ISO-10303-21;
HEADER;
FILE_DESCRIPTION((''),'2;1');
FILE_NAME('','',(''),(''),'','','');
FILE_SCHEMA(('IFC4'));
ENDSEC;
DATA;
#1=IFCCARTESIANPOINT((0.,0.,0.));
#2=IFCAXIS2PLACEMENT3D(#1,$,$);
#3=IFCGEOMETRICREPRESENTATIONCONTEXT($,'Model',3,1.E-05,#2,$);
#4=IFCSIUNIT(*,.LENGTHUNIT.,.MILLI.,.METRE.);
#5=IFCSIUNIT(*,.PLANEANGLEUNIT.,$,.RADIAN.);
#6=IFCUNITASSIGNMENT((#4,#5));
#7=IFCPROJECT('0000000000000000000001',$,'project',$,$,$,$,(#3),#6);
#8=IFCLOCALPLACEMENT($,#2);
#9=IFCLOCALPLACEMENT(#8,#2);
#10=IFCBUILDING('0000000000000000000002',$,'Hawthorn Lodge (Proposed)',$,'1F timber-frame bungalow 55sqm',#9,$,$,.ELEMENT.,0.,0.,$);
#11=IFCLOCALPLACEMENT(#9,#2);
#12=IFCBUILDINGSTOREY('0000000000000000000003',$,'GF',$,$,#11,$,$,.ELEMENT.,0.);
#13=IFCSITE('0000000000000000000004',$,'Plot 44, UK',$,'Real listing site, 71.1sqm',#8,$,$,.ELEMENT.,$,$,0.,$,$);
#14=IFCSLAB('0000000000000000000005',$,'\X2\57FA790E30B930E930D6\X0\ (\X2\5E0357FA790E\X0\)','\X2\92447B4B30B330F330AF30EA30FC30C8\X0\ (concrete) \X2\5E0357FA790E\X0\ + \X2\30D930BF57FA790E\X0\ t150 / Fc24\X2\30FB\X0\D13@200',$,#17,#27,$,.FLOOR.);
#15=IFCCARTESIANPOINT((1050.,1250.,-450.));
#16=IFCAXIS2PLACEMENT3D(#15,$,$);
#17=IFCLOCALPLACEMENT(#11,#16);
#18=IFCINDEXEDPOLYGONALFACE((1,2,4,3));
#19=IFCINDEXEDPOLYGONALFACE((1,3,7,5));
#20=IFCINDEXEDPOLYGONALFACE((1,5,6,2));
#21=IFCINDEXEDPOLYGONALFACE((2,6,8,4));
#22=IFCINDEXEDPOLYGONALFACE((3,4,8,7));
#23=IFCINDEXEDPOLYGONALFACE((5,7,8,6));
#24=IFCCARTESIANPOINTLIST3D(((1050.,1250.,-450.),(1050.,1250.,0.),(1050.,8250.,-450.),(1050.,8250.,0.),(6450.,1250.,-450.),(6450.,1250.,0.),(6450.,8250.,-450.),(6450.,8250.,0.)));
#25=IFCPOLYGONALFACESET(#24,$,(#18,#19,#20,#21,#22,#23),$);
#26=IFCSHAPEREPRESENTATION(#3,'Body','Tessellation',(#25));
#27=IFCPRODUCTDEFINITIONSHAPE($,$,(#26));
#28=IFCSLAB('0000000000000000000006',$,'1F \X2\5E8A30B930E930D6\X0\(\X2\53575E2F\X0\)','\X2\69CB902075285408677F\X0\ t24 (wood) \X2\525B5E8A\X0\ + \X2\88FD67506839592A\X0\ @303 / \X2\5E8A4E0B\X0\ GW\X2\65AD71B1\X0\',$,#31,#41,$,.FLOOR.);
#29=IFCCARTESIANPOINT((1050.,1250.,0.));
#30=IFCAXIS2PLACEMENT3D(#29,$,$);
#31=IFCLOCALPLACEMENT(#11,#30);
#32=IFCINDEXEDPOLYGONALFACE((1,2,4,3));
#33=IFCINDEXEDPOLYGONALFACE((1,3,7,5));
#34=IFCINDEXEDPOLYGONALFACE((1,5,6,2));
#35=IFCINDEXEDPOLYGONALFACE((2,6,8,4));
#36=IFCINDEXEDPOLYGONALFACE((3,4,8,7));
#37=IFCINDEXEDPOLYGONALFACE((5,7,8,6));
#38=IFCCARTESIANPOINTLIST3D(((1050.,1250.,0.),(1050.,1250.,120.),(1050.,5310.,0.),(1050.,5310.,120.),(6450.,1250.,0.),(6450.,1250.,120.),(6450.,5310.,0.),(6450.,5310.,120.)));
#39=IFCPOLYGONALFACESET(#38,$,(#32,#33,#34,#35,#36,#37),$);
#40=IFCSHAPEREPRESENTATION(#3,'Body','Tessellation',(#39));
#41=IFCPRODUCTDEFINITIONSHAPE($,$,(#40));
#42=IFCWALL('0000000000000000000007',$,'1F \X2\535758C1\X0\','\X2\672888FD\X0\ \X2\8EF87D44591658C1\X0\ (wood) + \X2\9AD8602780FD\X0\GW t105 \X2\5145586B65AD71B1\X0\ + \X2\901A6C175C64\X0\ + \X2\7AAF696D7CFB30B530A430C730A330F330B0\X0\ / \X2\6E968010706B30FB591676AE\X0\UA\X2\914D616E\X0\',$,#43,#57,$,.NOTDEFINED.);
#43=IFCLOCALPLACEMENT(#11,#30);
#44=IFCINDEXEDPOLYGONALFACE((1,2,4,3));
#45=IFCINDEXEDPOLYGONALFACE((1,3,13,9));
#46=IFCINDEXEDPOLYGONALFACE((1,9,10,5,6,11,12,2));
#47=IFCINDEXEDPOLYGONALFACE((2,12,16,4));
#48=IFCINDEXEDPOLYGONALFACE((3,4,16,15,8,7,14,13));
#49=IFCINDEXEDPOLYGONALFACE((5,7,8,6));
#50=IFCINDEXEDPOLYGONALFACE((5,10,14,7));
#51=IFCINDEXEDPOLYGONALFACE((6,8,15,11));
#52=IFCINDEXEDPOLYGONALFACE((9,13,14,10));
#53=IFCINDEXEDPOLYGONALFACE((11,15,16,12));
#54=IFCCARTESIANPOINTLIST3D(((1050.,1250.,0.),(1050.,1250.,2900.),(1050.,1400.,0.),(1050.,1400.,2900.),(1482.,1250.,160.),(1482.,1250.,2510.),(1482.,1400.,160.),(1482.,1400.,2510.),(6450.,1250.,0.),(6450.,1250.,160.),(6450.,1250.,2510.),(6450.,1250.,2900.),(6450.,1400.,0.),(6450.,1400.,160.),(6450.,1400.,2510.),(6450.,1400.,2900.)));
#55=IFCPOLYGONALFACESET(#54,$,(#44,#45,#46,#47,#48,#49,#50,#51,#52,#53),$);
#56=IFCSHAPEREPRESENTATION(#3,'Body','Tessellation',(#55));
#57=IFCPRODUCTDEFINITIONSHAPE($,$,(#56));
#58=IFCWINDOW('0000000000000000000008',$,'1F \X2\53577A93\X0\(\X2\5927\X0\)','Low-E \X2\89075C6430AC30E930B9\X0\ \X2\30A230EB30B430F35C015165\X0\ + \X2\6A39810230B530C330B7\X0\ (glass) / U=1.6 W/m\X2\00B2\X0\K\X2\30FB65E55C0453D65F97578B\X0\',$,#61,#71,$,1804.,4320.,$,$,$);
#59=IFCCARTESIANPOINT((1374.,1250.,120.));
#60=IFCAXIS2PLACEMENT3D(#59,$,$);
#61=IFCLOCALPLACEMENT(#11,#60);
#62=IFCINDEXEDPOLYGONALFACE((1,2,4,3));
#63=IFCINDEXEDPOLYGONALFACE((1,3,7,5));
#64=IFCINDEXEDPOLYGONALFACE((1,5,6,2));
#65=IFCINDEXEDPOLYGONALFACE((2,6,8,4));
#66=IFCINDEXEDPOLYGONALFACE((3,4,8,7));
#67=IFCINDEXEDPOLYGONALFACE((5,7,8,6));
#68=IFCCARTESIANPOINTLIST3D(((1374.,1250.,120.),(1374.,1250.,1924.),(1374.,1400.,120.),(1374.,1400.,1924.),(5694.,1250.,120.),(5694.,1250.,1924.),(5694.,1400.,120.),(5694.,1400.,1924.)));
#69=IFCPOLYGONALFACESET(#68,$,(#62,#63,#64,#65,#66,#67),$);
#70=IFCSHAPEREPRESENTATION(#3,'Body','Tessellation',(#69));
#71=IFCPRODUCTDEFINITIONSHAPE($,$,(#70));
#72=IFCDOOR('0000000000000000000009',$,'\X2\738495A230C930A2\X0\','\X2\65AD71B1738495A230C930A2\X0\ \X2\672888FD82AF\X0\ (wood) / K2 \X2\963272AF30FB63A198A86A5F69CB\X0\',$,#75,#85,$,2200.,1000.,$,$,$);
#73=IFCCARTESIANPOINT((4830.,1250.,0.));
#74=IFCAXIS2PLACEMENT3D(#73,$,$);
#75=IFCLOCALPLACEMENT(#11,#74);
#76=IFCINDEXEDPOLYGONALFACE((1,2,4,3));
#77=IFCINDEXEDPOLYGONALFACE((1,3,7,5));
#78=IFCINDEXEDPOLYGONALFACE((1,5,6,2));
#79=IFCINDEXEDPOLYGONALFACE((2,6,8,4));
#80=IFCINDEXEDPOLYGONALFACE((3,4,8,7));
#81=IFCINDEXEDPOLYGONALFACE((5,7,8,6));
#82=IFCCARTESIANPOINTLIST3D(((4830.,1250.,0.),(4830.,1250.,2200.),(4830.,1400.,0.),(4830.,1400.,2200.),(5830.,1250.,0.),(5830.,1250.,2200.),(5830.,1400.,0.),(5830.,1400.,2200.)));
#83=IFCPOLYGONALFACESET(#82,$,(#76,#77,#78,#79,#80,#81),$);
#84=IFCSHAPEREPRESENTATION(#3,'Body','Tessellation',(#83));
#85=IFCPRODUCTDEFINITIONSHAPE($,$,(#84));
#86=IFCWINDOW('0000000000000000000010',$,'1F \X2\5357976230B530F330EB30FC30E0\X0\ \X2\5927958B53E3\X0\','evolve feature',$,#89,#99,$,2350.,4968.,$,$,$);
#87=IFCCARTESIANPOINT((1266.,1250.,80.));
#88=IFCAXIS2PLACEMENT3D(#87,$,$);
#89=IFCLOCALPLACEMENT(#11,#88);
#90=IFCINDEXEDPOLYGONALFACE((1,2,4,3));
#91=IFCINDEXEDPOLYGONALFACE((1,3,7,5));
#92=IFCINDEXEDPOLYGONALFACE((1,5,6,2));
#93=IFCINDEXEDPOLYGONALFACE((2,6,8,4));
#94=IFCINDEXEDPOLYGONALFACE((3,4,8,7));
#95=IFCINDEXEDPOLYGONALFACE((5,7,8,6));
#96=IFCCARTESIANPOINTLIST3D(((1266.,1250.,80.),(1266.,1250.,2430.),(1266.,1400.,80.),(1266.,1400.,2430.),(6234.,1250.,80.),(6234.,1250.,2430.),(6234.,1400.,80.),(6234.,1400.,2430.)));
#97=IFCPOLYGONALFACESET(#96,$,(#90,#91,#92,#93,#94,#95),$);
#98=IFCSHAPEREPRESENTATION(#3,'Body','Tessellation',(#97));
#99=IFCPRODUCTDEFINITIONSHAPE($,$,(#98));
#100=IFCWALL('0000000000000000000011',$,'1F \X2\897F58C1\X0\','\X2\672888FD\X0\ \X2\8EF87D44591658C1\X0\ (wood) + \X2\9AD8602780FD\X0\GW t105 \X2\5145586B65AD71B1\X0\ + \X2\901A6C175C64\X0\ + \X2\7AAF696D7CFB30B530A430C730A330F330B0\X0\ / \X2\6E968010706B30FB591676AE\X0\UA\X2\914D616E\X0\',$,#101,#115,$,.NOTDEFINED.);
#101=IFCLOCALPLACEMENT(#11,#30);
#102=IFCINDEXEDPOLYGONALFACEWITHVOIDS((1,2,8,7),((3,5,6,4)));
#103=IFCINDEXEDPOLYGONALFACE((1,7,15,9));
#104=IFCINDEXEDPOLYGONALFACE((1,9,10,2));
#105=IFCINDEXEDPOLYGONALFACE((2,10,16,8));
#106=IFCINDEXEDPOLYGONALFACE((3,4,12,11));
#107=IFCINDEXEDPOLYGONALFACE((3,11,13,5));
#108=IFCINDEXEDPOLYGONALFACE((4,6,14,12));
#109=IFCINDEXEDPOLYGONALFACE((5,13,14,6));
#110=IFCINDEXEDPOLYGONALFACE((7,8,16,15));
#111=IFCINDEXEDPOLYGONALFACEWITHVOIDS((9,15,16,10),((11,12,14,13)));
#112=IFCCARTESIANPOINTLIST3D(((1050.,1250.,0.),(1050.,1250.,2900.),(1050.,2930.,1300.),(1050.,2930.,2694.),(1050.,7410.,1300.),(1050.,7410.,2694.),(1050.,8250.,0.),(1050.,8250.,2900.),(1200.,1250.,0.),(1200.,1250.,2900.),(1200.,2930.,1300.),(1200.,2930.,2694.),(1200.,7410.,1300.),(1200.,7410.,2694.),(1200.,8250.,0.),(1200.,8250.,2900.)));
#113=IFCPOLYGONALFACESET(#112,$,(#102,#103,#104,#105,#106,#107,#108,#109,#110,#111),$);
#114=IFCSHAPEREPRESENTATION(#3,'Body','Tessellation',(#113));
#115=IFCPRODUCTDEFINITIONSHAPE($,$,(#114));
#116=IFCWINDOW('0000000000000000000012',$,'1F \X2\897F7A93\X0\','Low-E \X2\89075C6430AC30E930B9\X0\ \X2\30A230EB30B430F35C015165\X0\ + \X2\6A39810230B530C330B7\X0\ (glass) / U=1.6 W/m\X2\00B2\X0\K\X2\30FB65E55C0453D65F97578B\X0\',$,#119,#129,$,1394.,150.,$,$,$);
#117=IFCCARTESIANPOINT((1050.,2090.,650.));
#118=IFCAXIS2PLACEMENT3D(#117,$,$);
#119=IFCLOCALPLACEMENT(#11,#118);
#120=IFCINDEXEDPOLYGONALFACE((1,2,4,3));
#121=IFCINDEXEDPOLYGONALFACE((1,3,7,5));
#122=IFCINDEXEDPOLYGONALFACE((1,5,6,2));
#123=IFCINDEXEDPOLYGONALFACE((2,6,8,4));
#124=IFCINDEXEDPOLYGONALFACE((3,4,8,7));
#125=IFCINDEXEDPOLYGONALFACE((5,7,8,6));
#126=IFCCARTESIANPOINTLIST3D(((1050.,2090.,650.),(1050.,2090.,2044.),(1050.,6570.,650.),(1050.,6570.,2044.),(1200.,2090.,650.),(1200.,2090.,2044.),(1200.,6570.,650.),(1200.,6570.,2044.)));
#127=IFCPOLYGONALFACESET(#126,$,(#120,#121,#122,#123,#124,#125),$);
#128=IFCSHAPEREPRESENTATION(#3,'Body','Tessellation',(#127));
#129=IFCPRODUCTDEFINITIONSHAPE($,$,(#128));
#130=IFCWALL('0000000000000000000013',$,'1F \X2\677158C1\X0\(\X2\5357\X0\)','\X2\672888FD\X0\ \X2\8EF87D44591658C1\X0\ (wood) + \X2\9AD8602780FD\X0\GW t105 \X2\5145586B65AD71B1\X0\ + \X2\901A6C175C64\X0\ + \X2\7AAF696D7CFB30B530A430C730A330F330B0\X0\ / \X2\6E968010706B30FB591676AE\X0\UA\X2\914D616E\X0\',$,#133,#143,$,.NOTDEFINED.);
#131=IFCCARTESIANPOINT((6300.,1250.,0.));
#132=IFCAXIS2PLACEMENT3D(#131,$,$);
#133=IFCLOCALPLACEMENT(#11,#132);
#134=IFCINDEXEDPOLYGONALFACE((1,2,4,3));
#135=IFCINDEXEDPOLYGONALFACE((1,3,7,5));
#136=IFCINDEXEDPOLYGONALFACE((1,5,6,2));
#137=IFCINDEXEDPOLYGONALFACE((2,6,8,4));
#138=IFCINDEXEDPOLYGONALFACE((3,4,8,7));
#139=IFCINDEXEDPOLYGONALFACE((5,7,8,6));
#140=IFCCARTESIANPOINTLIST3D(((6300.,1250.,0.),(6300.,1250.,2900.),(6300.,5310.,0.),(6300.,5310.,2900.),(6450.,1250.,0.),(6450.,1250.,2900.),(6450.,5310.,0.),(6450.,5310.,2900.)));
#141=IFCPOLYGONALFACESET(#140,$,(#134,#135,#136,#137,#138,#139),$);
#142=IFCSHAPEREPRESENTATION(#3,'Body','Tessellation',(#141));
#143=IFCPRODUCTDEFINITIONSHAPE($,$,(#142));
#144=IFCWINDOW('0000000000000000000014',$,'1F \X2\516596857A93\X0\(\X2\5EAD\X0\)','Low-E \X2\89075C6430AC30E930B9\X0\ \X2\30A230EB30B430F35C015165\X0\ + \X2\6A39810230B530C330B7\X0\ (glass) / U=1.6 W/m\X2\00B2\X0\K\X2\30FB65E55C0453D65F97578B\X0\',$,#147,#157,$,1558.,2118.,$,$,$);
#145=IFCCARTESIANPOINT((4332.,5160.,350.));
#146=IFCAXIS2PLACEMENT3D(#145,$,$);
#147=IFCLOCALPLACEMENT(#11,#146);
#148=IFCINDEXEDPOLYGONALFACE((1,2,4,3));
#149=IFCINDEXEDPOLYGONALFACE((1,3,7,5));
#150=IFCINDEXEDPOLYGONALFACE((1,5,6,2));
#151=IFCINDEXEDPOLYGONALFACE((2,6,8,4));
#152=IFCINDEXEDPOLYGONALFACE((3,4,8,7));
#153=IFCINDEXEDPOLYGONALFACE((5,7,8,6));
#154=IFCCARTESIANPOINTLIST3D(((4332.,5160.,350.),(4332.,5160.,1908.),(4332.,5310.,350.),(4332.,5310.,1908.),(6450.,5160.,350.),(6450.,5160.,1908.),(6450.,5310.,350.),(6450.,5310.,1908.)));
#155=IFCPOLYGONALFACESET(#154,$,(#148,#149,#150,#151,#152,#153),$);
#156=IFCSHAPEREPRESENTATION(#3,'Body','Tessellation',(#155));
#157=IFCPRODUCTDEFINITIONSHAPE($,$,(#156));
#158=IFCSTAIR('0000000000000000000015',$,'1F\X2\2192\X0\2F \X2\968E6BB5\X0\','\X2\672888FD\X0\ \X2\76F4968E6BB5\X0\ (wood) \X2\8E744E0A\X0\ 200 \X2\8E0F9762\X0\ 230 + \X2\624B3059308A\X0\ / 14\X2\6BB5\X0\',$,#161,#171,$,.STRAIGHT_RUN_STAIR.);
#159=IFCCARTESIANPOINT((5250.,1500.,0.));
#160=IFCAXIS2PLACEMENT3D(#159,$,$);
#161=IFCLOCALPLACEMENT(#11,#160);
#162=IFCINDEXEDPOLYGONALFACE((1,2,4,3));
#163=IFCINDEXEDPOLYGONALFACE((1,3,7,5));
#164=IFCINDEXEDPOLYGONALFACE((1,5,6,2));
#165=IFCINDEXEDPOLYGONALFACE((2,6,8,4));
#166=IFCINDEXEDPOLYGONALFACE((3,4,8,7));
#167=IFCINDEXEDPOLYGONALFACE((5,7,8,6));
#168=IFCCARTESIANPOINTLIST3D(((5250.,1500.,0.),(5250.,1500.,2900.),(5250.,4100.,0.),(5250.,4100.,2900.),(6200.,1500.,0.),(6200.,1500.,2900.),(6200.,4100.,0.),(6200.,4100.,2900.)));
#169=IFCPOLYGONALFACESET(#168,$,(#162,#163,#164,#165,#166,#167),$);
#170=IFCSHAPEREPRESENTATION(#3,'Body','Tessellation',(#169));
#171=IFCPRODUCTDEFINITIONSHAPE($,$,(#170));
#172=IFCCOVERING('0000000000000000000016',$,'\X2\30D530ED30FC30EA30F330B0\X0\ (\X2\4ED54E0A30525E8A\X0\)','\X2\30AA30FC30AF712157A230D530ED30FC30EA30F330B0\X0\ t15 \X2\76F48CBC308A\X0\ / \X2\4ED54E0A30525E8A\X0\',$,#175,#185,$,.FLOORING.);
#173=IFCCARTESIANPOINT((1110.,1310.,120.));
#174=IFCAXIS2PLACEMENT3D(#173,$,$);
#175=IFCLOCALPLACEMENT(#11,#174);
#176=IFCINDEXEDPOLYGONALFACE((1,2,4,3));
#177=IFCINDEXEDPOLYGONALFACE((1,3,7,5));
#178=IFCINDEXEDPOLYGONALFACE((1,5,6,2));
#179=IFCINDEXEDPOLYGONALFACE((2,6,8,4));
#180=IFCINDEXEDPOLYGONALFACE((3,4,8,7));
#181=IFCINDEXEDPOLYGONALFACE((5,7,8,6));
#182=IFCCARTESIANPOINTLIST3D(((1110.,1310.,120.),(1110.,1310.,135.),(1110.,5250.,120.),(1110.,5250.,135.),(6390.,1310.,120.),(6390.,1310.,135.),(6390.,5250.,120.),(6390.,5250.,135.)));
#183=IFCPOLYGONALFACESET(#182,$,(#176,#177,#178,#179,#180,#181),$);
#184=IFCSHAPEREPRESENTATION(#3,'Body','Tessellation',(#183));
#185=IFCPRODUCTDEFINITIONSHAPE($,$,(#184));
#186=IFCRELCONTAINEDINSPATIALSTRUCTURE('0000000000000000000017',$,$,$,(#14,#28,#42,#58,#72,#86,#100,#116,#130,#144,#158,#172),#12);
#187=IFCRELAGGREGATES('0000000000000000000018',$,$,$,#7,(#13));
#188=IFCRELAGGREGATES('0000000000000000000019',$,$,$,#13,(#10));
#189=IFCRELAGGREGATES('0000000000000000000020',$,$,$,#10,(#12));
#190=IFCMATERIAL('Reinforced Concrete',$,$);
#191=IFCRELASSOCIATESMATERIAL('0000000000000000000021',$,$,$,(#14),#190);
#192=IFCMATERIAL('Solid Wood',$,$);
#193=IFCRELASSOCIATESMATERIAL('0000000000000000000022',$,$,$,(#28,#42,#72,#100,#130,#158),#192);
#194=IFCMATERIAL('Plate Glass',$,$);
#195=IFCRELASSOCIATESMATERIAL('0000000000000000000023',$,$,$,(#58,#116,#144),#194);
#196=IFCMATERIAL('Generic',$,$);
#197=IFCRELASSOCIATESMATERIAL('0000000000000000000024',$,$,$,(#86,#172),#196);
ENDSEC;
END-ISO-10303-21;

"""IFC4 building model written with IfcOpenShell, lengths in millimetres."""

from ifc_helpers import new_model, si_unit, frame, frame_2d, origin, place, context, project, spatial, rectangle, extrude, material, element, fill, save


model = new_model("IFC4")

# Units and contexts
model_context = context("Model", 3, precision=1e-05, world=origin())
ifc_project = project(units=[si_unit("LENGTHUNIT", "METRE", prefix="MILLI"), si_unit("PLANEANGLEUNIT", "RADIAN")], contexts=[model_context])

# Site, building, storey
site_placement = place(None, origin())
site = spatial("IfcSite", under=ifc_project, at=site_placement, Name="Plot 44, UK", ObjectType="Real listing site, 71.1sqm", CompositionType="ELEMENT", RefElevation=0.0)
building_placement = place(site_placement, origin())
building = spatial("IfcBuilding", under=site, at=building_placement, Name="Hawthorn Lodge (Proposed)", ObjectType="1F timber-frame bungalow 55sqm", CompositionType="ELEMENT", ElevationOfRefHeight=0.0, ElevationOfTerrain=0.0)
storey_placement = place(building_placement, origin())
storey = spatial("IfcBuildingStorey", under=building, at=storey_placement, Name="GF", CompositionType="ELEMENT", Elevation=0.0)

# Slabs
ifc_material_1 = material(Name="Reinforced Concrete")
slab_1_placement = place(storey_placement, frame((1050.0, 1250.0, -450.0)))
element("IfcSlab", 1, at=slab_1_placement, inside=storey, material=ifc_material_1, Name="基礎スラブ (布基礎)", Description="鉄筋コンクリート (concrete) 布基礎 + ベタ基礎 t150 / Fc24・D13@200", PredefinedType="FLOOR", context=model_context, shape_type="SweptSolid", body=[
    extrude(rectangle(XDim=5400.0, YDim=7000.0, at=frame_2d((2700.0, 3500.0))), frame((1050.0, 1250.0, -450.0)), (0.0, 0.0, 1.0), 450.0),
])
ifc_material_2 = material(Name="Solid Wood")
slab_2_placement = place(storey_placement, frame((1050.0, 1250.0, 0.0)))
element("IfcSlab", 2, at=slab_2_placement, inside=storey, material=ifc_material_2, Name="1F 床スラブ(南帯)", Description="構造用合板 t24 (wood) 剛床 + 製材根太 @303 / 床下 GW断熱", PredefinedType="FLOOR", context=model_context, shape_type="SweptSolid", body=[
    extrude(rectangle(XDim=5400.0, YDim=4060.0, at=frame_2d((2700.0, 2030.0))), frame((1050.0, 1250.0, 0.0)), (0.0, 0.0, 1.0), 120.0),
])

# Wall, openings, windows, door
wall_1_placement = place(storey_placement, frame((1050.0, 1250.0, 0.0)))
wall_1 = element("IfcWall", 3, at=wall_1_placement, inside=storey, material=ifc_material_2, Name="1F 南壁", Description="木製 軸組外壁 (wood) + 高性能GW t105 充填断熱 + 通気層 + 窯業系サイディング / 準耐火・外皮UA配慮", PredefinedType="NOTDEFINED", context=model_context, shape_type="SweptSolid", body=[
    extrude(rectangle(XDim=5400.0, YDim=150.0, at=frame_2d((2700.0, 75.0))), frame((1050.0, 1250.0, 0.0)), (0.0, 0.0, 1.0), 2900.0),
])
opening_1_placement = place(storey_placement, frame((1374.0, 1250.0, 120.0)))
opening_1 = element("IfcOpeningElement", 4, at=opening_1_placement, cuts=wall_1, PredefinedType="NOTDEFINED", context=model_context, shape_type="SweptSolid", body=[
    extrude(rectangle(XDim=4320.0, YDim=150.0, at=frame_2d((2160.0, 75.0))), frame((1374.0, 1250.0, 120.0)), (0.0, 0.0, 1.0), 1804.0),
])
opening_2_placement = place(storey_placement, frame((4830.0, 1250.0, 0.0)))
opening_2 = element("IfcOpeningElement", 5, at=opening_2_placement, cuts=wall_1, PredefinedType="NOTDEFINED", context=model_context, shape_type="SweptSolid", body=[
    extrude(rectangle(XDim=1000.0, YDim=150.0, at=frame_2d((500.0, 75.0))), frame((4830.0, 1250.0, 0.0)), (0.0, 0.0, 1.0), 2200.0),
])
opening_3_placement = place(storey_placement, frame((1266.0, 1250.0, 80.0)))
opening_3 = element("IfcOpeningElement", 6, at=opening_3_placement, cuts=wall_1, PredefinedType="NOTDEFINED", context=model_context, shape_type="SweptSolid", body=[
    extrude(rectangle(XDim=4968.0, YDim=150.0, at=frame_2d((2484.0, 75.0))), frame((1266.0, 1250.0, 80.0)), (0.0, 0.0, 1.0), 2350.0),
])
ifc_material_3 = material(Name="Plate Glass")
window_1_placement = place(storey_placement, frame((1374.0, 1250.0, 120.0)))
window_1 = element("IfcWindow", 7, at=window_1_placement, inside=storey, material=ifc_material_3, Name="1F 南窓(大)", Description="Low-E 複層ガラス アルゴン封入 + 樹脂サッシ (glass) / U=1.6 W/m²K・日射取得型", OverallHeight=1804.0, OverallWidth=4320.0, context=model_context, shape_type="SweptSolid", body=[
    extrude(rectangle(XDim=4320.0, YDim=150.0, at=frame_2d((2160.0, 75.0))), frame((1374.0, 1250.0, 120.0)), (0.0, 0.0, 1.0), 1804.0),
])
fill(opening_1, window_1)
door_1_placement = place(storey_placement, frame((4830.0, 1250.0, 0.0)))
door_1 = element("IfcDoor", 8, at=door_1_placement, inside=storey, material=ifc_material_2, Name="玄関ドア", Description="断熱玄関ドア 木製芯 (wood) / K2 防犯・採風機構", OverallHeight=2200.0, OverallWidth=1000.0, context=model_context, shape_type="SweptSolid", body=[
    extrude(rectangle(XDim=1000.0, YDim=150.0, at=frame_2d((500.0, 75.0))), frame((4830.0, 1250.0, 0.0)), (0.0, 0.0, 1.0), 2200.0),
])
fill(opening_2, door_1)
ifc_material_4 = material(Name="Generic")
window_2_placement = place(storey_placement, frame((1266.0, 1250.0, 80.0)))
window_2 = element("IfcWindow", 9, at=window_2_placement, inside=storey, material=ifc_material_4, Name="1F 南面サンルーム 大開口", Description="evolve feature", OverallHeight=2350.0, OverallWidth=4968.0, context=model_context, shape_type="SweptSolid", body=[
    extrude(rectangle(XDim=4968.0, YDim=150.0, at=frame_2d((2484.0, 75.0))), frame((1266.0, 1250.0, 80.0)), (0.0, 0.0, 1.0), 2350.0),
])
fill(opening_3, window_2)

# Walls, openings, windows
wall_2_placement = place(storey_placement, frame((1050.0, 1250.0, 0.0)))
wall_2 = element("IfcWall", 10, at=wall_2_placement, inside=storey, material=ifc_material_2, Name="1F 西壁", Description="木製 軸組外壁 (wood) + 高性能GW t105 充填断熱 + 通気層 + 窯業系サイディング / 準耐火・外皮UA配慮", PredefinedType="NOTDEFINED", context=model_context, shape_type="SweptSolid", body=[
    extrude(rectangle(XDim=150.0, YDim=7000.0, at=frame_2d((75.0, 3500.0))), frame((1050.0, 1250.0, 0.0)), (0.0, 0.0, 1.0), 2900.0),
])
opening_4_placement = place(storey_placement, frame((1050.0, 2090.0, 650.0)))
opening_4 = element("IfcOpeningElement", 11, at=opening_4_placement, cuts=wall_2, PredefinedType="NOTDEFINED", context=model_context, shape_type="SweptSolid", body=[
    extrude(rectangle(XDim=150.0, YDim=4480.0, at=frame_2d((75.0, 2240.0))), frame((1050.0, 2090.0, 650.0)), (0.0, 0.0, 1.0), 1394.0),
])
window_3_placement = place(storey_placement, frame((1050.0, 2090.0, 650.0)))
window_3 = element("IfcWindow", 12, at=window_3_placement, inside=storey, material=ifc_material_3, Name="1F 西窓", Description="Low-E 複層ガラス アルゴン封入 + 樹脂サッシ (glass) / U=1.6 W/m²K・日射取得型", OverallHeight=1394.0, OverallWidth=150.0, context=model_context, shape_type="SweptSolid", body=[
    extrude(rectangle(XDim=150.0, YDim=4480.0, at=frame_2d((75.0, 2240.0))), frame((1050.0, 2090.0, 650.0)), (0.0, 0.0, 1.0), 1394.0),
])
fill(opening_4, window_3)
wall_3_placement = place(storey_placement, frame((6300.0, 1250.0, 0.0)))
wall_3 = element("IfcWall", 13, at=wall_3_placement, inside=storey, material=ifc_material_2, Name="1F 東壁(南)", Description="木製 軸組外壁 (wood) + 高性能GW t105 充填断熱 + 通気層 + 窯業系サイディング / 準耐火・外皮UA配慮", PredefinedType="NOTDEFINED", context=model_context, shape_type="SweptSolid", body=[
    extrude(rectangle(XDim=150.0, YDim=4060.0, at=frame_2d((75.0, 2030.0))), frame((6300.0, 1250.0, 0.0)), (0.0, 0.0, 1.0), 2900.0),
])
opening_5_placement = place(storey_placement, frame((4332.0, 5160.0, 350.0)))
opening_5 = element("IfcOpeningElement", 14, at=opening_5_placement, cuts=wall_3, PredefinedType="NOTDEFINED", context=model_context, shape_type="SweptSolid", body=[
    extrude(rectangle(XDim=2118.0, YDim=150.0, at=frame_2d((1059.0, 75.0))), frame((4332.0, 5160.0, 350.0)), (0.0, 0.0, 1.0), 1558.0),
])
window_4_placement = place(storey_placement, frame((4332.0, 5160.0, 350.0)))
window_4 = element("IfcWindow", 15, at=window_4_placement, inside=storey, material=ifc_material_3, Name="1F 入隅窓(庭)", Description="Low-E 複層ガラス アルゴン封入 + 樹脂サッシ (glass) / U=1.6 W/m²K・日射取得型", OverallHeight=1558.0, OverallWidth=2118.0, context=model_context, shape_type="SweptSolid", body=[
    extrude(rectangle(XDim=2118.0, YDim=150.0, at=frame_2d((1059.0, 75.0))), frame((4332.0, 5160.0, 350.0)), (0.0, 0.0, 1.0), 1558.0),
])
fill(opening_5, window_4)

# Stair
stair_placement = place(storey_placement, frame((5250.0, 1500.0, 0.0)))
element("IfcStair", 16, at=stair_placement, inside=storey, material=ifc_material_2, Name="1F→2F 階段", Description="木製 直階段 (wood) 蹴上 200 踏面 230 + 手すり / 14段", PredefinedType="STRAIGHT_RUN_STAIR", context=model_context, shape_type="SweptSolid", body=[
    extrude(rectangle(XDim=950.0, YDim=2600.0, at=frame_2d((475.0, 1300.0))), frame((5250.0, 1500.0, 0.0)), (0.0, 0.0, 1.0), 2900.0),
])

# Covering
covering_placement = place(storey_placement, frame((1110.0, 1310.0, 120.0)))
element("IfcCovering", 17, at=covering_placement, inside=storey, material=ifc_material_4, Name="フローリング (仕上げ床)", Description="オーク無垢フローリング t15 直貼り / 仕上げ床", PredefinedType="FLOORING", context=model_context, shape_type="SweptSolid", body=[
    extrude(rectangle(XDim=5280.0, YDim=3940.0, at=frame_2d((2640.0, 1970.0))), frame((1110.0, 1310.0, 120.0)), (0.0, 0.0, 1.0), 15.0),
])

save(model, "model.ifc")
